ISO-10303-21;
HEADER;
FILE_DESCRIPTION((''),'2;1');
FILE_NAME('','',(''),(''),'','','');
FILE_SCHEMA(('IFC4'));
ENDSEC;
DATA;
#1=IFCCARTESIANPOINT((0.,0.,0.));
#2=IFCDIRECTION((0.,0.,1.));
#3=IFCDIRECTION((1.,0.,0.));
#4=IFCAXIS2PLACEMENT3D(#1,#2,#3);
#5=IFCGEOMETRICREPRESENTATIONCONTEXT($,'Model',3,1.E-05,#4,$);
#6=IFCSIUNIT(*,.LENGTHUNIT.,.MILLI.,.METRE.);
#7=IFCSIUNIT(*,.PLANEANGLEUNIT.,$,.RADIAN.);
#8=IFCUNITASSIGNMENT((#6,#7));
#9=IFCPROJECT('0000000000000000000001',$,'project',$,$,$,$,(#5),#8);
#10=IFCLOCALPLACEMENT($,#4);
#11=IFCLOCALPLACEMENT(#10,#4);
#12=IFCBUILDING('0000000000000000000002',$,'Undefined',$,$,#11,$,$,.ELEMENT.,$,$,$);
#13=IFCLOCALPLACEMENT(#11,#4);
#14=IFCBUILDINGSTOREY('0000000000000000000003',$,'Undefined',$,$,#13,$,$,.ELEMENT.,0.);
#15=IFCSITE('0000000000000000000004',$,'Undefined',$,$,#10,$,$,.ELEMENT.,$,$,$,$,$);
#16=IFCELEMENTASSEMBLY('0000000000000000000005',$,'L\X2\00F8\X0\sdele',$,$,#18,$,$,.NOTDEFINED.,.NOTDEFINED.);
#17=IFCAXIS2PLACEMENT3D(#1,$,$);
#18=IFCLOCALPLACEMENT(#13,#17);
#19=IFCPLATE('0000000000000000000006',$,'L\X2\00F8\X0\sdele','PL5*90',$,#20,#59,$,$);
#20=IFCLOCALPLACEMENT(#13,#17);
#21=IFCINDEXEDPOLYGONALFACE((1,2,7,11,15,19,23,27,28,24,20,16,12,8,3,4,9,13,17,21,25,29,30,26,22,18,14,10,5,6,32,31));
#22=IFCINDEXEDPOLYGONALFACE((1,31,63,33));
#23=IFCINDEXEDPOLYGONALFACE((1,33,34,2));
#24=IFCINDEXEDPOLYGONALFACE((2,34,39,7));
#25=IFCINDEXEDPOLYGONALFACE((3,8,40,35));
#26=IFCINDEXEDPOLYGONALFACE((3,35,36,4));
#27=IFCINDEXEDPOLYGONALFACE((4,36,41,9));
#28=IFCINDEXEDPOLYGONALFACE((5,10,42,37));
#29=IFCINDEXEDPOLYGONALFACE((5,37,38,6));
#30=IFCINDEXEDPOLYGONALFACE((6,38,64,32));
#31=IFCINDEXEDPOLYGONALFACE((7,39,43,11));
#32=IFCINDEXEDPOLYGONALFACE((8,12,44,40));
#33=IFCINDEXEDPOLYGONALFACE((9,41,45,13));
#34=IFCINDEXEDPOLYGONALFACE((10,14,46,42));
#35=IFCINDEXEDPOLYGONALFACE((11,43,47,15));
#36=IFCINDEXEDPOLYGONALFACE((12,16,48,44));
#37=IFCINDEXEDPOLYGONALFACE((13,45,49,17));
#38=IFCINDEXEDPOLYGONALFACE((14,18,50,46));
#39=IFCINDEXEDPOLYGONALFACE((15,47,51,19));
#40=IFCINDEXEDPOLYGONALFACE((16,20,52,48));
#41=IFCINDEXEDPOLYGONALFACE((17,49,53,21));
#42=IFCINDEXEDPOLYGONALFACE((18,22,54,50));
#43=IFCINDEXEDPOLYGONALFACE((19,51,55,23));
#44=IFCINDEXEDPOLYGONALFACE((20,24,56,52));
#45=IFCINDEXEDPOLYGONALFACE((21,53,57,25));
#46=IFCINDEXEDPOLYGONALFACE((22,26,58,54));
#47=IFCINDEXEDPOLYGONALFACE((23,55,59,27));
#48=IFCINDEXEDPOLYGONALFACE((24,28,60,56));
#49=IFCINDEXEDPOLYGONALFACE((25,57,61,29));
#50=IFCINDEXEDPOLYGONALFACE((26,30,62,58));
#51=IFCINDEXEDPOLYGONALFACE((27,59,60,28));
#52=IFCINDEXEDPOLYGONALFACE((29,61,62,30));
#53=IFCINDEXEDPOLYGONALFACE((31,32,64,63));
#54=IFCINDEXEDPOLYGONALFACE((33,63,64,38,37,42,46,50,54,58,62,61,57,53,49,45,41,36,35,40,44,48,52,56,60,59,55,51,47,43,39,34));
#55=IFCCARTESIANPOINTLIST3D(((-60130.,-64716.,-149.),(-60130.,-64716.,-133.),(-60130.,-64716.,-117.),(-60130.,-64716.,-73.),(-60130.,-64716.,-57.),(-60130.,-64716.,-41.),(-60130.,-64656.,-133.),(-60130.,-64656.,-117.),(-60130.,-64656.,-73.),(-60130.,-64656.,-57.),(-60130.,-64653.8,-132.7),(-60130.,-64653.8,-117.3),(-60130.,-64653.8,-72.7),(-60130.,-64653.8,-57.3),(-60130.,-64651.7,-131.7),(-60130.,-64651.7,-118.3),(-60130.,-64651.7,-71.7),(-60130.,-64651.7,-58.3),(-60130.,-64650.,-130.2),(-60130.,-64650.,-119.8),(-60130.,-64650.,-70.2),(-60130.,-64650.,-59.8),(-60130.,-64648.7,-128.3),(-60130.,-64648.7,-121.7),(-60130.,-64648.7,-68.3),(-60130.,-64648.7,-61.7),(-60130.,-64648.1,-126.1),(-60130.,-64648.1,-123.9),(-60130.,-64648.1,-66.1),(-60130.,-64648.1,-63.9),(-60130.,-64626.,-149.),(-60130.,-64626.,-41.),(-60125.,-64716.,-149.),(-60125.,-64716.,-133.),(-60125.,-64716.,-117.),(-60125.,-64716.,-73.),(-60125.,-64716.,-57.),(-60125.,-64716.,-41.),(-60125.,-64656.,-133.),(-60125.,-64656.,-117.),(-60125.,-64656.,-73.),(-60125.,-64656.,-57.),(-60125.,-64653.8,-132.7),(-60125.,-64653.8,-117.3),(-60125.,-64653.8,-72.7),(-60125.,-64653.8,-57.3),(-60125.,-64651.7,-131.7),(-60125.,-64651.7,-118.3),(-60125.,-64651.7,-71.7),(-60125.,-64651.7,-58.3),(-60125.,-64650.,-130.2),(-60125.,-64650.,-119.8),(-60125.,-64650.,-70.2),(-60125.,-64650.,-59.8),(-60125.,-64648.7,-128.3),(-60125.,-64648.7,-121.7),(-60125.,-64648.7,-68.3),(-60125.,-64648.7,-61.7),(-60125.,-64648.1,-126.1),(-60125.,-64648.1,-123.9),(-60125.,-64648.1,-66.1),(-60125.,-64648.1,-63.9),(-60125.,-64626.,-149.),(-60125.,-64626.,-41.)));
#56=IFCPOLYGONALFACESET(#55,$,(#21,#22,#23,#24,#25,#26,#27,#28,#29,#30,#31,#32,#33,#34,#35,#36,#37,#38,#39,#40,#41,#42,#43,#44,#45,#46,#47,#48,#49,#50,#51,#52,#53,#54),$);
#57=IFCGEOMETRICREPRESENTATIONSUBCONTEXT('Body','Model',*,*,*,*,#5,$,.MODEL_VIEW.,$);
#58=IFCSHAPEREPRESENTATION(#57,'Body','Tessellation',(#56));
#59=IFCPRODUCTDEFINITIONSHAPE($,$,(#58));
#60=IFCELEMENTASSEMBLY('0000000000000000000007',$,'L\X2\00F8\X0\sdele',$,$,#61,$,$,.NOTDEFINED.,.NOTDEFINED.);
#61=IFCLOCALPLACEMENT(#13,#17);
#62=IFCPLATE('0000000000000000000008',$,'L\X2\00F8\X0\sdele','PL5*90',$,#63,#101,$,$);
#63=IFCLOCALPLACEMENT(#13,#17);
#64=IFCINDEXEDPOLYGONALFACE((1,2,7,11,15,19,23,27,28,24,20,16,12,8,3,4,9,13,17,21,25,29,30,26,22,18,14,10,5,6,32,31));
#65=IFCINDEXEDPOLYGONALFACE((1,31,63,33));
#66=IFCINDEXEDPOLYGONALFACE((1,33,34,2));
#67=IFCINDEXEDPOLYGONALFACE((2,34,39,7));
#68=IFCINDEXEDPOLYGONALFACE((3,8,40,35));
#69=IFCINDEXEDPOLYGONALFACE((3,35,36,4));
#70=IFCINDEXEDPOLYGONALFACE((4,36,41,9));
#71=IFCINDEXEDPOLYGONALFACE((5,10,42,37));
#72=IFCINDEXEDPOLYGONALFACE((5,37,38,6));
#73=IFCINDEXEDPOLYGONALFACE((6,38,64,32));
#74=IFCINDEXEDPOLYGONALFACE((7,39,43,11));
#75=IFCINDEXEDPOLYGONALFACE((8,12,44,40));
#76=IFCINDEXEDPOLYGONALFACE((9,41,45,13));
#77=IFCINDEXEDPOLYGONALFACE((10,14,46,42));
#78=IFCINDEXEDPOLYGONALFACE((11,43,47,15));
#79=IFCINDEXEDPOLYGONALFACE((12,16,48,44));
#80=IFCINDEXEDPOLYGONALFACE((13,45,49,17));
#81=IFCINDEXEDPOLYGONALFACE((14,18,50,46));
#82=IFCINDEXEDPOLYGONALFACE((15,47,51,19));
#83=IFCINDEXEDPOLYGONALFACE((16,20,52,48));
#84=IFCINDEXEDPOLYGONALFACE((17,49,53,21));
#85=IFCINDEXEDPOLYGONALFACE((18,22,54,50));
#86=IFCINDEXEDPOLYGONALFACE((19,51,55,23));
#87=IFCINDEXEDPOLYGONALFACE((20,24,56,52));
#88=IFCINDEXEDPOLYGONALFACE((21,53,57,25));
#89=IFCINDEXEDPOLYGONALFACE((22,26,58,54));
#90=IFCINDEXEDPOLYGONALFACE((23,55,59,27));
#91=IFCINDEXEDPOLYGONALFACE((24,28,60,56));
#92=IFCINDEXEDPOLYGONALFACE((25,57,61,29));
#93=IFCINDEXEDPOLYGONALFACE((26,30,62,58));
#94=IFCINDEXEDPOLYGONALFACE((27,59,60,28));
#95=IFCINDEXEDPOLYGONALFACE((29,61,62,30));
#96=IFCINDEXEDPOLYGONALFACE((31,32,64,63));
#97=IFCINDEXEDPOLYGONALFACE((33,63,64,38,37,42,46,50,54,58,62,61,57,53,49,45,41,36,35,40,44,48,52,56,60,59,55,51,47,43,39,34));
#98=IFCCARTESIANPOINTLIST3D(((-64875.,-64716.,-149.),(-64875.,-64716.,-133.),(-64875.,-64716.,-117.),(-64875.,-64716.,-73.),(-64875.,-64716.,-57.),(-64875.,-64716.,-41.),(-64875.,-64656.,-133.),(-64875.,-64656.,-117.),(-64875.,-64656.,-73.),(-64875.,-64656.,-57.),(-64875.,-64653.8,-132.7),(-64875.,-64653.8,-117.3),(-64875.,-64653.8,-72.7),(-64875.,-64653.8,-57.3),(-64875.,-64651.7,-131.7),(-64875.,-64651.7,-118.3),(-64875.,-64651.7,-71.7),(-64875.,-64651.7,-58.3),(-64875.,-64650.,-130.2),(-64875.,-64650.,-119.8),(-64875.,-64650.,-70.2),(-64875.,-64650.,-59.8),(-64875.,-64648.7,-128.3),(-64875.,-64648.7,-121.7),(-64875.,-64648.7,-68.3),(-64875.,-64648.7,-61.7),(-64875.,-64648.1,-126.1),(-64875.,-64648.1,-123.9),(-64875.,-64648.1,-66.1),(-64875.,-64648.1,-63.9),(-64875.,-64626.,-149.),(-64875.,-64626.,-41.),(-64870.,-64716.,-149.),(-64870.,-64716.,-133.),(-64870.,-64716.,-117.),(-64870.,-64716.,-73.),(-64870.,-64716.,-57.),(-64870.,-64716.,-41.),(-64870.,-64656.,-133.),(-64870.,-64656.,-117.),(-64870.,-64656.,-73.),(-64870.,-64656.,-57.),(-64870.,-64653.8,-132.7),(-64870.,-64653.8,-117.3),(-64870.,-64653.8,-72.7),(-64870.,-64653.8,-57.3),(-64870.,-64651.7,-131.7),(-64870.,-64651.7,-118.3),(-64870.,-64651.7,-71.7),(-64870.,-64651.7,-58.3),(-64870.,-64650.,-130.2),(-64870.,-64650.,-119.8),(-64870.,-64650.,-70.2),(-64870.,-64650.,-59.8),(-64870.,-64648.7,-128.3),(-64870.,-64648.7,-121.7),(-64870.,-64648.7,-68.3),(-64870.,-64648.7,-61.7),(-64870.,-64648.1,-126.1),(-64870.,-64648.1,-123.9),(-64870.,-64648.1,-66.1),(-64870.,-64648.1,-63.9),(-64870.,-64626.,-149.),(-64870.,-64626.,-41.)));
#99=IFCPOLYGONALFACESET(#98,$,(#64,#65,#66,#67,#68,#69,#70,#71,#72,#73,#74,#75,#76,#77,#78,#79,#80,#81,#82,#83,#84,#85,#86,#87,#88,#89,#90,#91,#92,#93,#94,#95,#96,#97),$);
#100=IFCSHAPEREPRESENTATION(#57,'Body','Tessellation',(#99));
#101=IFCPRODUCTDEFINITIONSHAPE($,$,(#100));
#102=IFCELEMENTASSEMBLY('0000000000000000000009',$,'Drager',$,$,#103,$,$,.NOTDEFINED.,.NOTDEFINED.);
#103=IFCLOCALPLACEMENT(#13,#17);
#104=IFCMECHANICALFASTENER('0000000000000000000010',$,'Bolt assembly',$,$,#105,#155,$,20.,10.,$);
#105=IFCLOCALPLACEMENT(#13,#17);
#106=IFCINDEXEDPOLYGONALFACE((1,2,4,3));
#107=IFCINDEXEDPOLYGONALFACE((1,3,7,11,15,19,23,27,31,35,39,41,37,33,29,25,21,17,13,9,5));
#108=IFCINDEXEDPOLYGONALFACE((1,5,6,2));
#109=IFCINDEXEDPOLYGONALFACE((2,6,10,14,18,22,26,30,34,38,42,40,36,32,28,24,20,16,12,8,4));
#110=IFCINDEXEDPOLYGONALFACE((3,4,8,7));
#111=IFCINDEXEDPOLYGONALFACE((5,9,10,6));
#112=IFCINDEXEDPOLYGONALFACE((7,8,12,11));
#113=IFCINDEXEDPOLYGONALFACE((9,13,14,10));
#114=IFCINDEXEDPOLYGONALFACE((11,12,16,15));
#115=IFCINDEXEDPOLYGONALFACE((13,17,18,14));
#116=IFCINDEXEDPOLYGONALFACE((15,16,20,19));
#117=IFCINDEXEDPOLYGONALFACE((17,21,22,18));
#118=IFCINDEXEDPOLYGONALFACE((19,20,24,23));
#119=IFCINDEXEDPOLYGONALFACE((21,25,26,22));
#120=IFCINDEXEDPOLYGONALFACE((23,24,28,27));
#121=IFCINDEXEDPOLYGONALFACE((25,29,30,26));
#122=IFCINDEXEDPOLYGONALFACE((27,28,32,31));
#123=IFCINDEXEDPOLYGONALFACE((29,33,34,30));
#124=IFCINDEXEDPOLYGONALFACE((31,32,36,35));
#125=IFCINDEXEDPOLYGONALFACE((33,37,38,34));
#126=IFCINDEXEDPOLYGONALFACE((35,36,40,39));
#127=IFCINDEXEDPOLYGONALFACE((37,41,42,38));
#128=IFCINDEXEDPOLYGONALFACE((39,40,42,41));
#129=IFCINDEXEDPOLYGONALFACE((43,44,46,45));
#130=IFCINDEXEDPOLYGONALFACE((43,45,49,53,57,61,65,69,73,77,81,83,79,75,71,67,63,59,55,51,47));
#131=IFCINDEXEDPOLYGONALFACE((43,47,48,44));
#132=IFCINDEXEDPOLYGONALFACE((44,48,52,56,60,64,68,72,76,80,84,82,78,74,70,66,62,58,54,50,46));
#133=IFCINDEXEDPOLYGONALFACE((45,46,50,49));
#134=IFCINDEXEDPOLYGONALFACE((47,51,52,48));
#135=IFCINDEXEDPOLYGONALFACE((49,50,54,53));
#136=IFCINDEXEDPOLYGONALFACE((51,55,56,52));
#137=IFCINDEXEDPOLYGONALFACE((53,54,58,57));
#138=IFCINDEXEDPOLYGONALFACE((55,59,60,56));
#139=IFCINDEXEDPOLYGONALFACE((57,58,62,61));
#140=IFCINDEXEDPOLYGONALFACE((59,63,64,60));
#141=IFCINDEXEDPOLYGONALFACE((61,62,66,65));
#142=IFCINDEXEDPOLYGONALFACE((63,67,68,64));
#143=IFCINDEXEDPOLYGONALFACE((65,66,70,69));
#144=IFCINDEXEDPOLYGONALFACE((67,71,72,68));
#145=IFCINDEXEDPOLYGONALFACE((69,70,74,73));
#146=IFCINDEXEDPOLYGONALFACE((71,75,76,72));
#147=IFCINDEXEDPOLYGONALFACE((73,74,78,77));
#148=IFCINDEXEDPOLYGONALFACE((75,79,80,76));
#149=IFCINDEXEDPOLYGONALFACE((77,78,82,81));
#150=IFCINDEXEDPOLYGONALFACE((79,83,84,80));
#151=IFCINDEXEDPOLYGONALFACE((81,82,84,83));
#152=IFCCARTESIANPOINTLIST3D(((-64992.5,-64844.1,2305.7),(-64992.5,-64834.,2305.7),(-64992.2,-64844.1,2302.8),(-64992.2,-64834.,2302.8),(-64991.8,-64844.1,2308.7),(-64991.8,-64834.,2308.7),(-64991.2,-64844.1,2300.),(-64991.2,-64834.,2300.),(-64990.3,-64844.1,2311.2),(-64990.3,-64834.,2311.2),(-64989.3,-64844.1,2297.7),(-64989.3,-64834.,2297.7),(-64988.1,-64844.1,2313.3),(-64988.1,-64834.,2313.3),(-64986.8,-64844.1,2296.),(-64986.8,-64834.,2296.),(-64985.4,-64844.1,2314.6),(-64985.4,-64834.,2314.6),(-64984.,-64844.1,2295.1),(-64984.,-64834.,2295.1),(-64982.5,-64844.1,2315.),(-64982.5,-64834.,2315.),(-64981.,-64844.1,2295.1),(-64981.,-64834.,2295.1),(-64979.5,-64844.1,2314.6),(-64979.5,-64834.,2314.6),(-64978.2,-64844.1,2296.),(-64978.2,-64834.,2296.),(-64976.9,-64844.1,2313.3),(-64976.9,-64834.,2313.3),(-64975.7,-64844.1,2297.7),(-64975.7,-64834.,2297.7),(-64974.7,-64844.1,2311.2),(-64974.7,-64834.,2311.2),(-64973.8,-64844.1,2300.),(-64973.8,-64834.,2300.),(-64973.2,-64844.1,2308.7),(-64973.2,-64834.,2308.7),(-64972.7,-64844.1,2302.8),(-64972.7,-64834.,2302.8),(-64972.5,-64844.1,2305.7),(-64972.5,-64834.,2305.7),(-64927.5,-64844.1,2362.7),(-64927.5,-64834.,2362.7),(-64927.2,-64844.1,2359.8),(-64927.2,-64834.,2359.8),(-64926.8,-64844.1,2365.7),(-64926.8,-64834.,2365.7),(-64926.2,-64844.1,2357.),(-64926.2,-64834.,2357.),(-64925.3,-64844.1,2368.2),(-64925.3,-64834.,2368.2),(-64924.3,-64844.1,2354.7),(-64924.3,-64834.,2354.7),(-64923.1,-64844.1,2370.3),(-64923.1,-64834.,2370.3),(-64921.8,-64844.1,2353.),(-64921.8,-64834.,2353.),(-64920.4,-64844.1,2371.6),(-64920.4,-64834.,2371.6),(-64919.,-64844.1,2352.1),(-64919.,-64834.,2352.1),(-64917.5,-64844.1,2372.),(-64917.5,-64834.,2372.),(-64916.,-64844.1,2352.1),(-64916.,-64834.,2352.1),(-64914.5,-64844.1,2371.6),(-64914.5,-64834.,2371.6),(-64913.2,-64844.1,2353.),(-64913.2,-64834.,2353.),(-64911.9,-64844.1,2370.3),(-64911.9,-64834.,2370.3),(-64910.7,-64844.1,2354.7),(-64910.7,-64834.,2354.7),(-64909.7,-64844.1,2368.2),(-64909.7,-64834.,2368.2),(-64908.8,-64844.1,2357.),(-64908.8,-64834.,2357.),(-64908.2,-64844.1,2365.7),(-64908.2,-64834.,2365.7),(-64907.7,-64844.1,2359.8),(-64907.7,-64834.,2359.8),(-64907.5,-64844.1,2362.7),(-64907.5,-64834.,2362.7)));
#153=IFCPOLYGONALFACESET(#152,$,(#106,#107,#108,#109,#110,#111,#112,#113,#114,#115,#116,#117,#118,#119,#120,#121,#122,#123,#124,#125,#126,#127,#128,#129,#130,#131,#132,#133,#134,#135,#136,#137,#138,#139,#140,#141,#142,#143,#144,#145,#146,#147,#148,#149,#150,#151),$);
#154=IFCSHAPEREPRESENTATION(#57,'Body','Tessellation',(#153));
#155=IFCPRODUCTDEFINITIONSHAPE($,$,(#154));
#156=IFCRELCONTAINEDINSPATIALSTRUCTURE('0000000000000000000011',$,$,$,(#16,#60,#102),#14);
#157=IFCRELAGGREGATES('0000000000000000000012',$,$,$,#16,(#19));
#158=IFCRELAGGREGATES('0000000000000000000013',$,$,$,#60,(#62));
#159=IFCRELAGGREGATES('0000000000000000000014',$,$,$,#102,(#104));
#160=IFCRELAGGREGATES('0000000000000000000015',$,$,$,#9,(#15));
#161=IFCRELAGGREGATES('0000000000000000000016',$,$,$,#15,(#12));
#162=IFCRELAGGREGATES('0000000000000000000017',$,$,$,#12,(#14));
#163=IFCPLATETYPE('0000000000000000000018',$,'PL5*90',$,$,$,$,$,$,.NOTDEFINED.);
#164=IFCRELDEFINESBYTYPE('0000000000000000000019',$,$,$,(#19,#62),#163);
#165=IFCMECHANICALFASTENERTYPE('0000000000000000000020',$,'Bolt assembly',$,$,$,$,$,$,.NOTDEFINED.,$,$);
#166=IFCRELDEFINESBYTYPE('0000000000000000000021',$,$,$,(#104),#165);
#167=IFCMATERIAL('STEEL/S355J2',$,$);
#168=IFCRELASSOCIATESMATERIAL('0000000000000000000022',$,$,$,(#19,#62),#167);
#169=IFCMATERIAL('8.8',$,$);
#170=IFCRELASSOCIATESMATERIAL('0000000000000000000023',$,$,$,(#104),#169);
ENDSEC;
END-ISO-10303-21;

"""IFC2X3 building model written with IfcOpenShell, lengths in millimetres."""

from ifc_helpers import new_model, si_unit, frame, frame_2d, origin_with_axes, origin_2d_with_axis, place, context, subcontext, project, spatial, polyline, circle_curve, parameter, trimmed, segment, composite_curve, circle, outline, extrude, boolean, source, transform, mapped, material, type_object, element, aggregate, save


model = new_model("IFC2X3")

# Units and contexts
model_context = context("Model", 3, precision=1e-05, world=origin_with_axes())
body_context = subcontext(model_context, "Body", "Model", "MODEL_VIEW")
ifc_project = project(units=[si_unit("LENGTHUNIT", "METRE", prefix="MILLI"), si_unit("PLANEANGLEUNIT", "RADIAN")], contexts=[model_context])

# Site, building, storey
site_placement = place(None, origin_with_axes())
site = spatial("IfcSite", under=ifc_project, at=site_placement, Name="Undefined", CompositionType="ELEMENT")
building_placement = place(site_placement, origin_with_axes())
building = spatial("IfcBuilding", under=site, at=building_placement, Name="Undefined", CompositionType="ELEMENT")
storey_placement = place(building_placement, origin_with_axes())
storey = spatial("IfcBuildingStorey", under=building, at=storey_placement, Name="Undefined", CompositionType="ELEMENT", Elevation=0.0)

# Shared definitions
ifc_material_1 = material(Name="STEEL/S355J2")

# Element assemblies, plates
assembly_1_placement = place(storey_placement, origin_with_axes())
assembly_1 = element("IfcElementAssembly", 1, at=assembly_1_placement, inside=storey, Name="Løsdele", AssemblyPlace="NOTDEFINED", PredefinedType="NOTDEFINED")
plate_type_1 = type_object("IfcPlateType", Name="PL5*90", PredefinedType="NOTDEFINED")
plate_1_placement = place(assembly_1_placement, frame((-60127.5, -64671.0, -41.0), z_axis=(-1.0, 0.0, 0.0), x_axis=(0.0, 0.0, -1.0)))
plate_1 = element("IfcPlate", 2, at=plate_1_placement, type_object=plate_type_1, material=ifc_material_1, Name="Løsdele", Description="PL5*90", context=body_context, shape_type="CSG", body=[
    boolean("DIFFERENCE", boolean("DIFFERENCE", extrude(outline(polyline([(0.0, -45.0), (0.0, 45.0), (108.0, 45.0), (108.0, -45.0), (0.0, -45.0)])), frame((0.0, 0.0, -2.5), z_axis=(0.0, 0.0, 1.0), x_axis=(1.0, 0.0, 0.0)), (0.0, 0.0, 1.0), 5.0), extrude(outline(composite_curve([segment(polyline([(0.0, 0.0), (60.0, 0.0), (60.0, 16.0), (0.0, 16.0)]), True, "CONTINUOUS"), segment(trimmed(circle_curve(frame_2d((0.0, 8.0), x_axis=(0.0, 1.0)), 8.0), [parameter(0.0)], [parameter(1.570796)], True, "PARAMETER"), True, "CONTINUOUS"), segment(polyline([(-8.0, 8.0), (-8.0, 8.0)]), True, "CONTINUOUS"), segment(trimmed(circle_curve(frame_2d((0.0, 8.0), x_axis=(-1.0, 0.0)), 8.0), [parameter(0.0)], [parameter(1.570796)], True, "PARAMETER"), True, "CONTINUOUS"), segment(polyline([(0.0, 0.0), (0.0, 0.0)]), True, "CONTINUOUS")], self_intersect=True)), frame((92.0, -15.0, -2.5), z_axis=(0.0, 0.0, 1.0), x_axis=(0.0, 1.0, 0.0)), (0.0, 0.0, 1.0), 5.0)), extrude(outline(composite_curve([segment(polyline([(0.0, 0.0), (60.0, 0.0), (60.0, 16.0), (0.0, 16.0)]), True, "CONTINUOUS"), segment(trimmed(circle_curve(frame_2d((0.0, 8.0), x_axis=(0.0, 1.0)), 8.0), [parameter(0.0)], [parameter(1.570796)], True, "PARAMETER"), True, "CONTINUOUS"), segment(polyline([(-8.0, 8.0), (-8.0, 8.0)]), True, "CONTINUOUS"), segment(trimmed(circle_curve(frame_2d((0.0, 8.0), x_axis=(-1.0, 0.0)), 8.0), [parameter(0.0)], [parameter(1.570796)], True, "PARAMETER"), True, "CONTINUOUS"), segment(polyline([(0.0, 0.0), (0.0, 0.0)]), True, "CONTINUOUS")], self_intersect=True)), frame((32.0, -15.0, -2.5), z_axis=(0.0, 0.0, 1.0), x_axis=(0.0, 1.0, 0.0)), (0.0, 0.0, 1.0), 5.0)),
])
aggregate(assembly_1, [plate_1])
assembly_2_placement = place(storey_placement, origin_with_axes())
assembly_2 = element("IfcElementAssembly", 3, at=assembly_2_placement, inside=storey, Name="Løsdele", AssemblyPlace="NOTDEFINED", PredefinedType="NOTDEFINED")
plate_2_placement = place(assembly_2_placement, frame((-64872.5, -64671.0, -149.0), z_axis=(1.0, 0.0, 0.0), x_axis=(0.0, 0.0, 1.0)))
plate_2 = element("IfcPlate", 4, at=plate_2_placement, type_object=plate_type_1, material=ifc_material_1, Name="Løsdele", Description="PL5*90", context=body_context, shape_type="CSG", body=[
    boolean("DIFFERENCE", boolean("DIFFERENCE", extrude(outline(polyline([(0.0, -45.0), (0.0, 45.0), (108.0, 45.0), (108.0, -45.0), (0.0, -45.0)])), frame((0.0, 0.0, -2.5), z_axis=(0.0, 0.0, 1.0), x_axis=(1.0, 0.0, 0.0)), (0.0, 0.0, 1.0), 5.0), extrude(outline(composite_curve([segment(polyline([(0.0, 0.0), (60.0, 0.0), (60.0, 16.0), (0.0, 16.0)]), True, "CONTINUOUS"), segment(trimmed(circle_curve(frame_2d((0.0, 8.0), x_axis=(0.0, 1.0)), 8.0), [parameter(0.0)], [parameter(1.570796)], True, "PARAMETER"), True, "CONTINUOUS"), segment(polyline([(-8.0, 8.0), (-8.0, 8.0)]), True, "CONTINUOUS"), segment(trimmed(circle_curve(frame_2d((0.0, 8.0), x_axis=(-1.0, 0.0)), 8.0), [parameter(0.0)], [parameter(1.570796)], True, "PARAMETER"), True, "CONTINUOUS"), segment(polyline([(0.0, 0.0), (0.0, 0.0)]), True, "CONTINUOUS")], self_intersect=True)), frame((92.0, -15.0, -2.5), z_axis=(0.0, 0.0, 1.0), x_axis=(0.0, 1.0, 0.0)), (0.0, 0.0, 1.0), 5.0)), extrude(outline(composite_curve([segment(polyline([(0.0, 0.0), (60.0, 0.0), (60.0, 16.0), (0.0, 16.0)]), True, "CONTINUOUS"), segment(trimmed(circle_curve(frame_2d((0.0, 8.0), x_axis=(0.0, 1.0)), 8.0), [parameter(0.0)], [parameter(1.570796)], True, "PARAMETER"), True, "CONTINUOUS"), segment(polyline([(-8.0, 8.0), (-8.0, 8.0)]), True, "CONTINUOUS"), segment(trimmed(circle_curve(frame_2d((0.0, 8.0), x_axis=(-1.0, 0.0)), 8.0), [parameter(0.0)], [parameter(1.570796)], True, "PARAMETER"), True, "CONTINUOUS"), segment(polyline([(0.0, 0.0), (0.0, 0.0)]), True, "CONTINUOUS")], self_intersect=True)), frame((32.0, -15.0, -2.5), z_axis=(0.0, 0.0, 1.0), x_axis=(0.0, 1.0, 0.0)), (0.0, 0.0, 1.0), 5.0)),
])
aggregate(assembly_2, [plate_2])

# Element assembly, mechanical fastener
assembly_3_placement = place(storey_placement, origin_with_axes())
assembly_3 = element("IfcElementAssembly", 5, at=assembly_3_placement, inside=storey, Name="Drager", AssemblyPlace="NOTDEFINED", PredefinedType="NOTDEFINED")
ifc_material_2 = material(Name="8.8")
mechanical_fastener_type = type_object("IfcMechanicalFastenerType", Name="Bolt assembly")
shared_shape_1 = source(origin_with_axes(), body_context, "Body", "SweptSolid", [
    extrude(circle(Radius=10.0, at=origin_2d_with_axis()), frame((0.0, 0.0, 0.0), z_axis=(0.0, 1.0, 0.0), x_axis=(1.0, 0.0, 0.0)), (0.0, 0.0, 1.0), 10.1),
])
mechanical_fastener_1_placement = place(assembly_3_placement, frame((-64950.0, -64834.0, 2305.0), z_axis=(1.0, 0.0, 0.0), x_axis=(0.0, 0.0, 1.0)))
mechanical_fastener_1 = element("IfcMechanicalFastener", 6, at=mechanical_fastener_1_placement, type_object=mechanical_fastener_type, material=ifc_material_2, Name="Bolt assembly", NominalDiameter=20.0, NominalLength=10.0, context=body_context, shape_type="MappedRepresentation", body=[
    mapped(shared_shape_1, transform((0.0, 0.0, -32.5))),
    mapped(shared_shape_1, transform((57.0, 0.0, 32.5))),
])
aggregate(assembly_3, [mechanical_fastener_1])

save(model, "model.ifc")
